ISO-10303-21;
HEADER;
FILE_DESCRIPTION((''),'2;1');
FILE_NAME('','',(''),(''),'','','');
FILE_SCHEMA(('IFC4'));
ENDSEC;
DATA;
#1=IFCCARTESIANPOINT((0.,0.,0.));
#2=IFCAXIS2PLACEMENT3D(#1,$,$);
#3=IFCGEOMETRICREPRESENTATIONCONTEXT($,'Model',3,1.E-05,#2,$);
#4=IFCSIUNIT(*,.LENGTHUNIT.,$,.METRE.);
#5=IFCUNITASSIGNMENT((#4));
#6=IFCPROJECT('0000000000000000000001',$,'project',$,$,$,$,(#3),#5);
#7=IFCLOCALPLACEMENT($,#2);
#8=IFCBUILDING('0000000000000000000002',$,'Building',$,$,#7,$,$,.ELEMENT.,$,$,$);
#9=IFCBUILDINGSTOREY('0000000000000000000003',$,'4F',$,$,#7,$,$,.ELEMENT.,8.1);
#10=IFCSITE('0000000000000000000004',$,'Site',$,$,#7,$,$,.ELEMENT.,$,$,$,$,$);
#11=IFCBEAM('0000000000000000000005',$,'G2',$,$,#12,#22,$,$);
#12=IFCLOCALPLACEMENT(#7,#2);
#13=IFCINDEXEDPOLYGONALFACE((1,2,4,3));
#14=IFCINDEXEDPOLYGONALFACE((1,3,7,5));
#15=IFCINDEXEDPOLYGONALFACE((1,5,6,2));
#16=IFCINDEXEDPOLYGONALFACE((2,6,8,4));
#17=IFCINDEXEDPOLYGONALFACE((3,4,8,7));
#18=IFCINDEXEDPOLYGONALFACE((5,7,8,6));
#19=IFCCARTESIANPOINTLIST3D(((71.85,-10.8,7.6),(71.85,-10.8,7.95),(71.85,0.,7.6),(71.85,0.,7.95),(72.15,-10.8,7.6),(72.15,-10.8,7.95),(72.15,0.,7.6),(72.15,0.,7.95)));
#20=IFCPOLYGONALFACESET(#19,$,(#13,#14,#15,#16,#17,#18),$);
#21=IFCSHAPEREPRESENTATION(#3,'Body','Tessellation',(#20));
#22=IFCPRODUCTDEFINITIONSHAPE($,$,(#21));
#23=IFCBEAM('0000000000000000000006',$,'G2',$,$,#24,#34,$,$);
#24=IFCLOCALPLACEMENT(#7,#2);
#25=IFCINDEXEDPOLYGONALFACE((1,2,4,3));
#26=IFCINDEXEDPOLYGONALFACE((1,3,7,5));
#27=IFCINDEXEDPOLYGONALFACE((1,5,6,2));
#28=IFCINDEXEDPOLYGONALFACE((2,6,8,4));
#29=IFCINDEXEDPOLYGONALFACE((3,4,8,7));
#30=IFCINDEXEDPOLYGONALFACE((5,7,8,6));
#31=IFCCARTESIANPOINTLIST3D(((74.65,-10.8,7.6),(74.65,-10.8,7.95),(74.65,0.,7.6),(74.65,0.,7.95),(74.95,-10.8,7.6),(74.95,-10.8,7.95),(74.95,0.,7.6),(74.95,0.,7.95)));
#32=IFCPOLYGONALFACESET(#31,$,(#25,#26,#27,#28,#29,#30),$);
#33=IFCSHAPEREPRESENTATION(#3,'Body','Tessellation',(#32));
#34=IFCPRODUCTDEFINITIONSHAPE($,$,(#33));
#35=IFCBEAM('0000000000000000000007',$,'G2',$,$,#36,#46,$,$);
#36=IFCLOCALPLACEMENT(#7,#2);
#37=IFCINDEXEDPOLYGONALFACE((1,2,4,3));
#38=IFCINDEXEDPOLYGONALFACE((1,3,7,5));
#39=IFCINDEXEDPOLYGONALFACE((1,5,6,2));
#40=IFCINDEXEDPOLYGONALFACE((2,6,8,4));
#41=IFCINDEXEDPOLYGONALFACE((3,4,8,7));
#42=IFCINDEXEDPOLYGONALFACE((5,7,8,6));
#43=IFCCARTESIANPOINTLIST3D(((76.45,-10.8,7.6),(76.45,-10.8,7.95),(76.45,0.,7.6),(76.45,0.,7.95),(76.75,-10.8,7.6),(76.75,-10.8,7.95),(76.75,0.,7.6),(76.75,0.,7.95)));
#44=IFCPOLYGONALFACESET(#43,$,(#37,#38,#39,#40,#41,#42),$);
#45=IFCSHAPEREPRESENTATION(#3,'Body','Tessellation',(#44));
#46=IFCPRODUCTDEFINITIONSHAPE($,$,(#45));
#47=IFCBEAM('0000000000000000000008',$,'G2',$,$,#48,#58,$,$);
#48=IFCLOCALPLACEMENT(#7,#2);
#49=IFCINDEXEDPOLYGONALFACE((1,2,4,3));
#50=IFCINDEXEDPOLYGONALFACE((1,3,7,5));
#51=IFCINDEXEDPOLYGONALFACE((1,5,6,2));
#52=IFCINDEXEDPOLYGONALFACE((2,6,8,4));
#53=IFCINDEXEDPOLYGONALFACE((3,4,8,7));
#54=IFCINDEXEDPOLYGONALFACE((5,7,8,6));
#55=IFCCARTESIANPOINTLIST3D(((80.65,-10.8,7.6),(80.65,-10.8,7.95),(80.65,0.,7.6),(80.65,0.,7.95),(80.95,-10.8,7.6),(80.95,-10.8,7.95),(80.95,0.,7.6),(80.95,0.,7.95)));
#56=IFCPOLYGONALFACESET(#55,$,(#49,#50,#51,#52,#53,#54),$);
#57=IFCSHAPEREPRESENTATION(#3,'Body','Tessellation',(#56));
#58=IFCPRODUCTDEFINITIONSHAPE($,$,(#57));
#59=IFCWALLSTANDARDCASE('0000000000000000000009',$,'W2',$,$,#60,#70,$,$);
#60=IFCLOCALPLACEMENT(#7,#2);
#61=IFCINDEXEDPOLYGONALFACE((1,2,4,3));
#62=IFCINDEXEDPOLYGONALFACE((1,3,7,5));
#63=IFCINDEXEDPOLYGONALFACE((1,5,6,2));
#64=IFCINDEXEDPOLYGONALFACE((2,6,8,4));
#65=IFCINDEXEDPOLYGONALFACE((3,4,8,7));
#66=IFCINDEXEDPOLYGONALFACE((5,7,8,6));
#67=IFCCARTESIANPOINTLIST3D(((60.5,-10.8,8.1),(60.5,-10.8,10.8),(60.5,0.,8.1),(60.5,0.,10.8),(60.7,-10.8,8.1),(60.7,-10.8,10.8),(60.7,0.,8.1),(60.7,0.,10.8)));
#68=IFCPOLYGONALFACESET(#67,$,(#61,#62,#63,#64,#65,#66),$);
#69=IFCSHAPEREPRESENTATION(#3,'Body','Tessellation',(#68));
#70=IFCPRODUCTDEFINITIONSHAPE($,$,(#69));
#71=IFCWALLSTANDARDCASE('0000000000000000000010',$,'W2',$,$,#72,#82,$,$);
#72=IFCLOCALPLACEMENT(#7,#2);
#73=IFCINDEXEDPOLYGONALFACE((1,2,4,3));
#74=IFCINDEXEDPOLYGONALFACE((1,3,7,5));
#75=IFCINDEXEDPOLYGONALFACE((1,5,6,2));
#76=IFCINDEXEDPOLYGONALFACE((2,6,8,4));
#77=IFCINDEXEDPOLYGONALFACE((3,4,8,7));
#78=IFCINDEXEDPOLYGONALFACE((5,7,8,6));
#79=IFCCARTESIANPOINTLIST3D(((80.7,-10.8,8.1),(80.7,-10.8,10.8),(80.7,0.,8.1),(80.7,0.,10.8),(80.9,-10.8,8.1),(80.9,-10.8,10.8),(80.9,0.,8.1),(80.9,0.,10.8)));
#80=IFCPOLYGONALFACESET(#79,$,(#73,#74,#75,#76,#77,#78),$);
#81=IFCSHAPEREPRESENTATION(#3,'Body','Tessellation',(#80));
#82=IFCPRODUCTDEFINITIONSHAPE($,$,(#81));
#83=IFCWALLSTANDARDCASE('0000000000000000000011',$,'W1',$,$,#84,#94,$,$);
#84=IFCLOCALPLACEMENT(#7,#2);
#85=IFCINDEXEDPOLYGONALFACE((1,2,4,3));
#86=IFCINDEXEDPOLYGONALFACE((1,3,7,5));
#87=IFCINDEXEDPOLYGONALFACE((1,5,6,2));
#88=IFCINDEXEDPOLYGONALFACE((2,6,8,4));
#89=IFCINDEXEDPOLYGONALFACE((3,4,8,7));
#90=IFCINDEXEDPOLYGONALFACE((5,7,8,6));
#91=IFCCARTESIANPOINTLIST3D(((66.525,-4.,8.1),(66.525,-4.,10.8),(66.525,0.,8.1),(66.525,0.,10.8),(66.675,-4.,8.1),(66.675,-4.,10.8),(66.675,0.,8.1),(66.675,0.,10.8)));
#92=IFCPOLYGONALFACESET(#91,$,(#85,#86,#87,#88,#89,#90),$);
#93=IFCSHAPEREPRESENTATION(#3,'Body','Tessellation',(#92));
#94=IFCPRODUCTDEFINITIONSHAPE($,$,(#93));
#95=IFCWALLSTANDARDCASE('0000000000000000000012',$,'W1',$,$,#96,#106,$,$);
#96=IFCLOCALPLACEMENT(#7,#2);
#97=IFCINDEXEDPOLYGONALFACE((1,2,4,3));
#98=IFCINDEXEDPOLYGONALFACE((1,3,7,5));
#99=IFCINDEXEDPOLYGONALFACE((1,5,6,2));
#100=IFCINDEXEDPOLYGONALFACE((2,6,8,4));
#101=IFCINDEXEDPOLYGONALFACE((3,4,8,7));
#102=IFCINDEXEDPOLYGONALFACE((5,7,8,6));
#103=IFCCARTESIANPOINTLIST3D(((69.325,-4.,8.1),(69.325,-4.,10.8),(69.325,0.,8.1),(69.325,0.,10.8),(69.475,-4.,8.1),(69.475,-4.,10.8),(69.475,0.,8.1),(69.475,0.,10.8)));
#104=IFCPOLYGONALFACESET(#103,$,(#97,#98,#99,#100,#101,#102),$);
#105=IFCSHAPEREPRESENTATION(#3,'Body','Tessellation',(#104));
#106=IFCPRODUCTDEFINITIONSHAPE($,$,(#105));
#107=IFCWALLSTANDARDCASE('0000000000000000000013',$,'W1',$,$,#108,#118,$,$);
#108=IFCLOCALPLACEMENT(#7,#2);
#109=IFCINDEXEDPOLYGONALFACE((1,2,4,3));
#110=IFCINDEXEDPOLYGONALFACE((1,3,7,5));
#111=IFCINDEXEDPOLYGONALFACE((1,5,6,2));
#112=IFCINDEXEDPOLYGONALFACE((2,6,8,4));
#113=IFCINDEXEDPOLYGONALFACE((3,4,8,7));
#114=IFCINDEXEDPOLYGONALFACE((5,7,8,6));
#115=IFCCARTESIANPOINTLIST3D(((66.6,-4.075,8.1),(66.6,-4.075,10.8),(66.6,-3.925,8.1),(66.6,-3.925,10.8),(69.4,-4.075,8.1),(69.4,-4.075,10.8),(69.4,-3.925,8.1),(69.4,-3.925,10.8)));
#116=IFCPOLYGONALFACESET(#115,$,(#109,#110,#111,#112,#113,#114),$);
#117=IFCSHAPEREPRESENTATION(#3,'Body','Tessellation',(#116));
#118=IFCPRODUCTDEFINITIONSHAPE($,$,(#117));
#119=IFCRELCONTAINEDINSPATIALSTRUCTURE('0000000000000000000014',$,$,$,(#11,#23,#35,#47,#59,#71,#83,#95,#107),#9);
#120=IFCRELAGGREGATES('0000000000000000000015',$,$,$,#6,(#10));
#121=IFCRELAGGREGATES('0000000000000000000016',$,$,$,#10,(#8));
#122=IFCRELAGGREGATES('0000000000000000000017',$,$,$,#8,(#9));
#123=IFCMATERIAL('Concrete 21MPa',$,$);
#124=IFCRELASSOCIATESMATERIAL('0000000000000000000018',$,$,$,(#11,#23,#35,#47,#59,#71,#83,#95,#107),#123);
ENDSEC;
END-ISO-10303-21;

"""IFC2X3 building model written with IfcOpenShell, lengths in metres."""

from ifc_helpers import new_model, si_unit, frame, origin, origin_2d, place, context, project, spatial, rectangle, extrude, material, element, save


model = new_model("IFC2X3")

# Units and contexts
model_context = context("Model", 3, precision=1e-05, world=origin())
ifc_project = project(units=[si_unit("LENGTHUNIT", "METRE")], contexts=[model_context])

# Site, building, storey
placement = place(None, origin())
site = spatial("IfcSite", under=ifc_project, at=placement, Name="Site", CompositionType="ELEMENT")
building = spatial("IfcBuilding", under=site, at=placement, Name="Building", CompositionType="ELEMENT")
storey = spatial("IfcBuildingStorey", under=building, at=placement, Name="4F", CompositionType="ELEMENT", Elevation=8.1)

# Shared definitions
ifc_material = material(Name="Concrete 21MPa")

# Beams
for number, where, name in (
    (1, (72.0, -5.4, 7.6), "G2"),
    (2, (74.8, -5.4, 7.6), "G2"),
    (3, (76.6, -5.4, 7.6), "G2"),
    (4, (80.8, -5.4, 7.6), "G2"),
):
    element("IfcBeam", number, at=place(None, frame(where)), inside=storey, material=ifc_material, Name=name, context=model_context, shape_type="SweptSolid", body=[
        extrude(rectangle(XDim=0.3, YDim=10.8, at=origin_2d()), origin(), (0.0, 0.0, 1.0), 0.35),
    ])

# Walls
for number, where, name in (
    (5, (60.6, -5.4, 8.1), "W2"),
    (6, (80.8, -5.4, 8.1), "W2"),
):
    element("IfcWallStandardCase", number, at=place(None, frame(where)), inside=storey, material=ifc_material, Name=name, context=model_context, shape_type="SweptSolid", body=[
        extrude(rectangle(XDim=0.2, YDim=10.8, at=origin_2d()), origin(), (0.0, 0.0, 1.0), 2.7),
    ])
for number, where, name in (
    (7, (66.6, -2.0, 8.1), "W1"),
    (8, (69.4, -2.0, 8.1), "W1"),
):
    element("IfcWallStandardCase", number, at=place(None, frame(where)), inside=storey, material=ifc_material, Name=name, context=model_context, shape_type="SweptSolid", body=[
        extrude(rectangle(XDim=0.15, YDim=4.0, at=origin_2d()), origin(), (0.0, 0.0, 1.0), 2.7),
    ])
wall_placement = place(None, frame((68.0, -4.0, 8.1)))
element("IfcWallStandardCase", 9, at=wall_placement, inside=storey, material=ifc_material, Name="W1", context=model_context, shape_type="SweptSolid", body=[
    extrude(rectangle(XDim=2.8, YDim=0.15, at=origin_2d()), origin(), (0.0, 0.0, 1.0), 2.7),
])

save(model, "model.ifc")
